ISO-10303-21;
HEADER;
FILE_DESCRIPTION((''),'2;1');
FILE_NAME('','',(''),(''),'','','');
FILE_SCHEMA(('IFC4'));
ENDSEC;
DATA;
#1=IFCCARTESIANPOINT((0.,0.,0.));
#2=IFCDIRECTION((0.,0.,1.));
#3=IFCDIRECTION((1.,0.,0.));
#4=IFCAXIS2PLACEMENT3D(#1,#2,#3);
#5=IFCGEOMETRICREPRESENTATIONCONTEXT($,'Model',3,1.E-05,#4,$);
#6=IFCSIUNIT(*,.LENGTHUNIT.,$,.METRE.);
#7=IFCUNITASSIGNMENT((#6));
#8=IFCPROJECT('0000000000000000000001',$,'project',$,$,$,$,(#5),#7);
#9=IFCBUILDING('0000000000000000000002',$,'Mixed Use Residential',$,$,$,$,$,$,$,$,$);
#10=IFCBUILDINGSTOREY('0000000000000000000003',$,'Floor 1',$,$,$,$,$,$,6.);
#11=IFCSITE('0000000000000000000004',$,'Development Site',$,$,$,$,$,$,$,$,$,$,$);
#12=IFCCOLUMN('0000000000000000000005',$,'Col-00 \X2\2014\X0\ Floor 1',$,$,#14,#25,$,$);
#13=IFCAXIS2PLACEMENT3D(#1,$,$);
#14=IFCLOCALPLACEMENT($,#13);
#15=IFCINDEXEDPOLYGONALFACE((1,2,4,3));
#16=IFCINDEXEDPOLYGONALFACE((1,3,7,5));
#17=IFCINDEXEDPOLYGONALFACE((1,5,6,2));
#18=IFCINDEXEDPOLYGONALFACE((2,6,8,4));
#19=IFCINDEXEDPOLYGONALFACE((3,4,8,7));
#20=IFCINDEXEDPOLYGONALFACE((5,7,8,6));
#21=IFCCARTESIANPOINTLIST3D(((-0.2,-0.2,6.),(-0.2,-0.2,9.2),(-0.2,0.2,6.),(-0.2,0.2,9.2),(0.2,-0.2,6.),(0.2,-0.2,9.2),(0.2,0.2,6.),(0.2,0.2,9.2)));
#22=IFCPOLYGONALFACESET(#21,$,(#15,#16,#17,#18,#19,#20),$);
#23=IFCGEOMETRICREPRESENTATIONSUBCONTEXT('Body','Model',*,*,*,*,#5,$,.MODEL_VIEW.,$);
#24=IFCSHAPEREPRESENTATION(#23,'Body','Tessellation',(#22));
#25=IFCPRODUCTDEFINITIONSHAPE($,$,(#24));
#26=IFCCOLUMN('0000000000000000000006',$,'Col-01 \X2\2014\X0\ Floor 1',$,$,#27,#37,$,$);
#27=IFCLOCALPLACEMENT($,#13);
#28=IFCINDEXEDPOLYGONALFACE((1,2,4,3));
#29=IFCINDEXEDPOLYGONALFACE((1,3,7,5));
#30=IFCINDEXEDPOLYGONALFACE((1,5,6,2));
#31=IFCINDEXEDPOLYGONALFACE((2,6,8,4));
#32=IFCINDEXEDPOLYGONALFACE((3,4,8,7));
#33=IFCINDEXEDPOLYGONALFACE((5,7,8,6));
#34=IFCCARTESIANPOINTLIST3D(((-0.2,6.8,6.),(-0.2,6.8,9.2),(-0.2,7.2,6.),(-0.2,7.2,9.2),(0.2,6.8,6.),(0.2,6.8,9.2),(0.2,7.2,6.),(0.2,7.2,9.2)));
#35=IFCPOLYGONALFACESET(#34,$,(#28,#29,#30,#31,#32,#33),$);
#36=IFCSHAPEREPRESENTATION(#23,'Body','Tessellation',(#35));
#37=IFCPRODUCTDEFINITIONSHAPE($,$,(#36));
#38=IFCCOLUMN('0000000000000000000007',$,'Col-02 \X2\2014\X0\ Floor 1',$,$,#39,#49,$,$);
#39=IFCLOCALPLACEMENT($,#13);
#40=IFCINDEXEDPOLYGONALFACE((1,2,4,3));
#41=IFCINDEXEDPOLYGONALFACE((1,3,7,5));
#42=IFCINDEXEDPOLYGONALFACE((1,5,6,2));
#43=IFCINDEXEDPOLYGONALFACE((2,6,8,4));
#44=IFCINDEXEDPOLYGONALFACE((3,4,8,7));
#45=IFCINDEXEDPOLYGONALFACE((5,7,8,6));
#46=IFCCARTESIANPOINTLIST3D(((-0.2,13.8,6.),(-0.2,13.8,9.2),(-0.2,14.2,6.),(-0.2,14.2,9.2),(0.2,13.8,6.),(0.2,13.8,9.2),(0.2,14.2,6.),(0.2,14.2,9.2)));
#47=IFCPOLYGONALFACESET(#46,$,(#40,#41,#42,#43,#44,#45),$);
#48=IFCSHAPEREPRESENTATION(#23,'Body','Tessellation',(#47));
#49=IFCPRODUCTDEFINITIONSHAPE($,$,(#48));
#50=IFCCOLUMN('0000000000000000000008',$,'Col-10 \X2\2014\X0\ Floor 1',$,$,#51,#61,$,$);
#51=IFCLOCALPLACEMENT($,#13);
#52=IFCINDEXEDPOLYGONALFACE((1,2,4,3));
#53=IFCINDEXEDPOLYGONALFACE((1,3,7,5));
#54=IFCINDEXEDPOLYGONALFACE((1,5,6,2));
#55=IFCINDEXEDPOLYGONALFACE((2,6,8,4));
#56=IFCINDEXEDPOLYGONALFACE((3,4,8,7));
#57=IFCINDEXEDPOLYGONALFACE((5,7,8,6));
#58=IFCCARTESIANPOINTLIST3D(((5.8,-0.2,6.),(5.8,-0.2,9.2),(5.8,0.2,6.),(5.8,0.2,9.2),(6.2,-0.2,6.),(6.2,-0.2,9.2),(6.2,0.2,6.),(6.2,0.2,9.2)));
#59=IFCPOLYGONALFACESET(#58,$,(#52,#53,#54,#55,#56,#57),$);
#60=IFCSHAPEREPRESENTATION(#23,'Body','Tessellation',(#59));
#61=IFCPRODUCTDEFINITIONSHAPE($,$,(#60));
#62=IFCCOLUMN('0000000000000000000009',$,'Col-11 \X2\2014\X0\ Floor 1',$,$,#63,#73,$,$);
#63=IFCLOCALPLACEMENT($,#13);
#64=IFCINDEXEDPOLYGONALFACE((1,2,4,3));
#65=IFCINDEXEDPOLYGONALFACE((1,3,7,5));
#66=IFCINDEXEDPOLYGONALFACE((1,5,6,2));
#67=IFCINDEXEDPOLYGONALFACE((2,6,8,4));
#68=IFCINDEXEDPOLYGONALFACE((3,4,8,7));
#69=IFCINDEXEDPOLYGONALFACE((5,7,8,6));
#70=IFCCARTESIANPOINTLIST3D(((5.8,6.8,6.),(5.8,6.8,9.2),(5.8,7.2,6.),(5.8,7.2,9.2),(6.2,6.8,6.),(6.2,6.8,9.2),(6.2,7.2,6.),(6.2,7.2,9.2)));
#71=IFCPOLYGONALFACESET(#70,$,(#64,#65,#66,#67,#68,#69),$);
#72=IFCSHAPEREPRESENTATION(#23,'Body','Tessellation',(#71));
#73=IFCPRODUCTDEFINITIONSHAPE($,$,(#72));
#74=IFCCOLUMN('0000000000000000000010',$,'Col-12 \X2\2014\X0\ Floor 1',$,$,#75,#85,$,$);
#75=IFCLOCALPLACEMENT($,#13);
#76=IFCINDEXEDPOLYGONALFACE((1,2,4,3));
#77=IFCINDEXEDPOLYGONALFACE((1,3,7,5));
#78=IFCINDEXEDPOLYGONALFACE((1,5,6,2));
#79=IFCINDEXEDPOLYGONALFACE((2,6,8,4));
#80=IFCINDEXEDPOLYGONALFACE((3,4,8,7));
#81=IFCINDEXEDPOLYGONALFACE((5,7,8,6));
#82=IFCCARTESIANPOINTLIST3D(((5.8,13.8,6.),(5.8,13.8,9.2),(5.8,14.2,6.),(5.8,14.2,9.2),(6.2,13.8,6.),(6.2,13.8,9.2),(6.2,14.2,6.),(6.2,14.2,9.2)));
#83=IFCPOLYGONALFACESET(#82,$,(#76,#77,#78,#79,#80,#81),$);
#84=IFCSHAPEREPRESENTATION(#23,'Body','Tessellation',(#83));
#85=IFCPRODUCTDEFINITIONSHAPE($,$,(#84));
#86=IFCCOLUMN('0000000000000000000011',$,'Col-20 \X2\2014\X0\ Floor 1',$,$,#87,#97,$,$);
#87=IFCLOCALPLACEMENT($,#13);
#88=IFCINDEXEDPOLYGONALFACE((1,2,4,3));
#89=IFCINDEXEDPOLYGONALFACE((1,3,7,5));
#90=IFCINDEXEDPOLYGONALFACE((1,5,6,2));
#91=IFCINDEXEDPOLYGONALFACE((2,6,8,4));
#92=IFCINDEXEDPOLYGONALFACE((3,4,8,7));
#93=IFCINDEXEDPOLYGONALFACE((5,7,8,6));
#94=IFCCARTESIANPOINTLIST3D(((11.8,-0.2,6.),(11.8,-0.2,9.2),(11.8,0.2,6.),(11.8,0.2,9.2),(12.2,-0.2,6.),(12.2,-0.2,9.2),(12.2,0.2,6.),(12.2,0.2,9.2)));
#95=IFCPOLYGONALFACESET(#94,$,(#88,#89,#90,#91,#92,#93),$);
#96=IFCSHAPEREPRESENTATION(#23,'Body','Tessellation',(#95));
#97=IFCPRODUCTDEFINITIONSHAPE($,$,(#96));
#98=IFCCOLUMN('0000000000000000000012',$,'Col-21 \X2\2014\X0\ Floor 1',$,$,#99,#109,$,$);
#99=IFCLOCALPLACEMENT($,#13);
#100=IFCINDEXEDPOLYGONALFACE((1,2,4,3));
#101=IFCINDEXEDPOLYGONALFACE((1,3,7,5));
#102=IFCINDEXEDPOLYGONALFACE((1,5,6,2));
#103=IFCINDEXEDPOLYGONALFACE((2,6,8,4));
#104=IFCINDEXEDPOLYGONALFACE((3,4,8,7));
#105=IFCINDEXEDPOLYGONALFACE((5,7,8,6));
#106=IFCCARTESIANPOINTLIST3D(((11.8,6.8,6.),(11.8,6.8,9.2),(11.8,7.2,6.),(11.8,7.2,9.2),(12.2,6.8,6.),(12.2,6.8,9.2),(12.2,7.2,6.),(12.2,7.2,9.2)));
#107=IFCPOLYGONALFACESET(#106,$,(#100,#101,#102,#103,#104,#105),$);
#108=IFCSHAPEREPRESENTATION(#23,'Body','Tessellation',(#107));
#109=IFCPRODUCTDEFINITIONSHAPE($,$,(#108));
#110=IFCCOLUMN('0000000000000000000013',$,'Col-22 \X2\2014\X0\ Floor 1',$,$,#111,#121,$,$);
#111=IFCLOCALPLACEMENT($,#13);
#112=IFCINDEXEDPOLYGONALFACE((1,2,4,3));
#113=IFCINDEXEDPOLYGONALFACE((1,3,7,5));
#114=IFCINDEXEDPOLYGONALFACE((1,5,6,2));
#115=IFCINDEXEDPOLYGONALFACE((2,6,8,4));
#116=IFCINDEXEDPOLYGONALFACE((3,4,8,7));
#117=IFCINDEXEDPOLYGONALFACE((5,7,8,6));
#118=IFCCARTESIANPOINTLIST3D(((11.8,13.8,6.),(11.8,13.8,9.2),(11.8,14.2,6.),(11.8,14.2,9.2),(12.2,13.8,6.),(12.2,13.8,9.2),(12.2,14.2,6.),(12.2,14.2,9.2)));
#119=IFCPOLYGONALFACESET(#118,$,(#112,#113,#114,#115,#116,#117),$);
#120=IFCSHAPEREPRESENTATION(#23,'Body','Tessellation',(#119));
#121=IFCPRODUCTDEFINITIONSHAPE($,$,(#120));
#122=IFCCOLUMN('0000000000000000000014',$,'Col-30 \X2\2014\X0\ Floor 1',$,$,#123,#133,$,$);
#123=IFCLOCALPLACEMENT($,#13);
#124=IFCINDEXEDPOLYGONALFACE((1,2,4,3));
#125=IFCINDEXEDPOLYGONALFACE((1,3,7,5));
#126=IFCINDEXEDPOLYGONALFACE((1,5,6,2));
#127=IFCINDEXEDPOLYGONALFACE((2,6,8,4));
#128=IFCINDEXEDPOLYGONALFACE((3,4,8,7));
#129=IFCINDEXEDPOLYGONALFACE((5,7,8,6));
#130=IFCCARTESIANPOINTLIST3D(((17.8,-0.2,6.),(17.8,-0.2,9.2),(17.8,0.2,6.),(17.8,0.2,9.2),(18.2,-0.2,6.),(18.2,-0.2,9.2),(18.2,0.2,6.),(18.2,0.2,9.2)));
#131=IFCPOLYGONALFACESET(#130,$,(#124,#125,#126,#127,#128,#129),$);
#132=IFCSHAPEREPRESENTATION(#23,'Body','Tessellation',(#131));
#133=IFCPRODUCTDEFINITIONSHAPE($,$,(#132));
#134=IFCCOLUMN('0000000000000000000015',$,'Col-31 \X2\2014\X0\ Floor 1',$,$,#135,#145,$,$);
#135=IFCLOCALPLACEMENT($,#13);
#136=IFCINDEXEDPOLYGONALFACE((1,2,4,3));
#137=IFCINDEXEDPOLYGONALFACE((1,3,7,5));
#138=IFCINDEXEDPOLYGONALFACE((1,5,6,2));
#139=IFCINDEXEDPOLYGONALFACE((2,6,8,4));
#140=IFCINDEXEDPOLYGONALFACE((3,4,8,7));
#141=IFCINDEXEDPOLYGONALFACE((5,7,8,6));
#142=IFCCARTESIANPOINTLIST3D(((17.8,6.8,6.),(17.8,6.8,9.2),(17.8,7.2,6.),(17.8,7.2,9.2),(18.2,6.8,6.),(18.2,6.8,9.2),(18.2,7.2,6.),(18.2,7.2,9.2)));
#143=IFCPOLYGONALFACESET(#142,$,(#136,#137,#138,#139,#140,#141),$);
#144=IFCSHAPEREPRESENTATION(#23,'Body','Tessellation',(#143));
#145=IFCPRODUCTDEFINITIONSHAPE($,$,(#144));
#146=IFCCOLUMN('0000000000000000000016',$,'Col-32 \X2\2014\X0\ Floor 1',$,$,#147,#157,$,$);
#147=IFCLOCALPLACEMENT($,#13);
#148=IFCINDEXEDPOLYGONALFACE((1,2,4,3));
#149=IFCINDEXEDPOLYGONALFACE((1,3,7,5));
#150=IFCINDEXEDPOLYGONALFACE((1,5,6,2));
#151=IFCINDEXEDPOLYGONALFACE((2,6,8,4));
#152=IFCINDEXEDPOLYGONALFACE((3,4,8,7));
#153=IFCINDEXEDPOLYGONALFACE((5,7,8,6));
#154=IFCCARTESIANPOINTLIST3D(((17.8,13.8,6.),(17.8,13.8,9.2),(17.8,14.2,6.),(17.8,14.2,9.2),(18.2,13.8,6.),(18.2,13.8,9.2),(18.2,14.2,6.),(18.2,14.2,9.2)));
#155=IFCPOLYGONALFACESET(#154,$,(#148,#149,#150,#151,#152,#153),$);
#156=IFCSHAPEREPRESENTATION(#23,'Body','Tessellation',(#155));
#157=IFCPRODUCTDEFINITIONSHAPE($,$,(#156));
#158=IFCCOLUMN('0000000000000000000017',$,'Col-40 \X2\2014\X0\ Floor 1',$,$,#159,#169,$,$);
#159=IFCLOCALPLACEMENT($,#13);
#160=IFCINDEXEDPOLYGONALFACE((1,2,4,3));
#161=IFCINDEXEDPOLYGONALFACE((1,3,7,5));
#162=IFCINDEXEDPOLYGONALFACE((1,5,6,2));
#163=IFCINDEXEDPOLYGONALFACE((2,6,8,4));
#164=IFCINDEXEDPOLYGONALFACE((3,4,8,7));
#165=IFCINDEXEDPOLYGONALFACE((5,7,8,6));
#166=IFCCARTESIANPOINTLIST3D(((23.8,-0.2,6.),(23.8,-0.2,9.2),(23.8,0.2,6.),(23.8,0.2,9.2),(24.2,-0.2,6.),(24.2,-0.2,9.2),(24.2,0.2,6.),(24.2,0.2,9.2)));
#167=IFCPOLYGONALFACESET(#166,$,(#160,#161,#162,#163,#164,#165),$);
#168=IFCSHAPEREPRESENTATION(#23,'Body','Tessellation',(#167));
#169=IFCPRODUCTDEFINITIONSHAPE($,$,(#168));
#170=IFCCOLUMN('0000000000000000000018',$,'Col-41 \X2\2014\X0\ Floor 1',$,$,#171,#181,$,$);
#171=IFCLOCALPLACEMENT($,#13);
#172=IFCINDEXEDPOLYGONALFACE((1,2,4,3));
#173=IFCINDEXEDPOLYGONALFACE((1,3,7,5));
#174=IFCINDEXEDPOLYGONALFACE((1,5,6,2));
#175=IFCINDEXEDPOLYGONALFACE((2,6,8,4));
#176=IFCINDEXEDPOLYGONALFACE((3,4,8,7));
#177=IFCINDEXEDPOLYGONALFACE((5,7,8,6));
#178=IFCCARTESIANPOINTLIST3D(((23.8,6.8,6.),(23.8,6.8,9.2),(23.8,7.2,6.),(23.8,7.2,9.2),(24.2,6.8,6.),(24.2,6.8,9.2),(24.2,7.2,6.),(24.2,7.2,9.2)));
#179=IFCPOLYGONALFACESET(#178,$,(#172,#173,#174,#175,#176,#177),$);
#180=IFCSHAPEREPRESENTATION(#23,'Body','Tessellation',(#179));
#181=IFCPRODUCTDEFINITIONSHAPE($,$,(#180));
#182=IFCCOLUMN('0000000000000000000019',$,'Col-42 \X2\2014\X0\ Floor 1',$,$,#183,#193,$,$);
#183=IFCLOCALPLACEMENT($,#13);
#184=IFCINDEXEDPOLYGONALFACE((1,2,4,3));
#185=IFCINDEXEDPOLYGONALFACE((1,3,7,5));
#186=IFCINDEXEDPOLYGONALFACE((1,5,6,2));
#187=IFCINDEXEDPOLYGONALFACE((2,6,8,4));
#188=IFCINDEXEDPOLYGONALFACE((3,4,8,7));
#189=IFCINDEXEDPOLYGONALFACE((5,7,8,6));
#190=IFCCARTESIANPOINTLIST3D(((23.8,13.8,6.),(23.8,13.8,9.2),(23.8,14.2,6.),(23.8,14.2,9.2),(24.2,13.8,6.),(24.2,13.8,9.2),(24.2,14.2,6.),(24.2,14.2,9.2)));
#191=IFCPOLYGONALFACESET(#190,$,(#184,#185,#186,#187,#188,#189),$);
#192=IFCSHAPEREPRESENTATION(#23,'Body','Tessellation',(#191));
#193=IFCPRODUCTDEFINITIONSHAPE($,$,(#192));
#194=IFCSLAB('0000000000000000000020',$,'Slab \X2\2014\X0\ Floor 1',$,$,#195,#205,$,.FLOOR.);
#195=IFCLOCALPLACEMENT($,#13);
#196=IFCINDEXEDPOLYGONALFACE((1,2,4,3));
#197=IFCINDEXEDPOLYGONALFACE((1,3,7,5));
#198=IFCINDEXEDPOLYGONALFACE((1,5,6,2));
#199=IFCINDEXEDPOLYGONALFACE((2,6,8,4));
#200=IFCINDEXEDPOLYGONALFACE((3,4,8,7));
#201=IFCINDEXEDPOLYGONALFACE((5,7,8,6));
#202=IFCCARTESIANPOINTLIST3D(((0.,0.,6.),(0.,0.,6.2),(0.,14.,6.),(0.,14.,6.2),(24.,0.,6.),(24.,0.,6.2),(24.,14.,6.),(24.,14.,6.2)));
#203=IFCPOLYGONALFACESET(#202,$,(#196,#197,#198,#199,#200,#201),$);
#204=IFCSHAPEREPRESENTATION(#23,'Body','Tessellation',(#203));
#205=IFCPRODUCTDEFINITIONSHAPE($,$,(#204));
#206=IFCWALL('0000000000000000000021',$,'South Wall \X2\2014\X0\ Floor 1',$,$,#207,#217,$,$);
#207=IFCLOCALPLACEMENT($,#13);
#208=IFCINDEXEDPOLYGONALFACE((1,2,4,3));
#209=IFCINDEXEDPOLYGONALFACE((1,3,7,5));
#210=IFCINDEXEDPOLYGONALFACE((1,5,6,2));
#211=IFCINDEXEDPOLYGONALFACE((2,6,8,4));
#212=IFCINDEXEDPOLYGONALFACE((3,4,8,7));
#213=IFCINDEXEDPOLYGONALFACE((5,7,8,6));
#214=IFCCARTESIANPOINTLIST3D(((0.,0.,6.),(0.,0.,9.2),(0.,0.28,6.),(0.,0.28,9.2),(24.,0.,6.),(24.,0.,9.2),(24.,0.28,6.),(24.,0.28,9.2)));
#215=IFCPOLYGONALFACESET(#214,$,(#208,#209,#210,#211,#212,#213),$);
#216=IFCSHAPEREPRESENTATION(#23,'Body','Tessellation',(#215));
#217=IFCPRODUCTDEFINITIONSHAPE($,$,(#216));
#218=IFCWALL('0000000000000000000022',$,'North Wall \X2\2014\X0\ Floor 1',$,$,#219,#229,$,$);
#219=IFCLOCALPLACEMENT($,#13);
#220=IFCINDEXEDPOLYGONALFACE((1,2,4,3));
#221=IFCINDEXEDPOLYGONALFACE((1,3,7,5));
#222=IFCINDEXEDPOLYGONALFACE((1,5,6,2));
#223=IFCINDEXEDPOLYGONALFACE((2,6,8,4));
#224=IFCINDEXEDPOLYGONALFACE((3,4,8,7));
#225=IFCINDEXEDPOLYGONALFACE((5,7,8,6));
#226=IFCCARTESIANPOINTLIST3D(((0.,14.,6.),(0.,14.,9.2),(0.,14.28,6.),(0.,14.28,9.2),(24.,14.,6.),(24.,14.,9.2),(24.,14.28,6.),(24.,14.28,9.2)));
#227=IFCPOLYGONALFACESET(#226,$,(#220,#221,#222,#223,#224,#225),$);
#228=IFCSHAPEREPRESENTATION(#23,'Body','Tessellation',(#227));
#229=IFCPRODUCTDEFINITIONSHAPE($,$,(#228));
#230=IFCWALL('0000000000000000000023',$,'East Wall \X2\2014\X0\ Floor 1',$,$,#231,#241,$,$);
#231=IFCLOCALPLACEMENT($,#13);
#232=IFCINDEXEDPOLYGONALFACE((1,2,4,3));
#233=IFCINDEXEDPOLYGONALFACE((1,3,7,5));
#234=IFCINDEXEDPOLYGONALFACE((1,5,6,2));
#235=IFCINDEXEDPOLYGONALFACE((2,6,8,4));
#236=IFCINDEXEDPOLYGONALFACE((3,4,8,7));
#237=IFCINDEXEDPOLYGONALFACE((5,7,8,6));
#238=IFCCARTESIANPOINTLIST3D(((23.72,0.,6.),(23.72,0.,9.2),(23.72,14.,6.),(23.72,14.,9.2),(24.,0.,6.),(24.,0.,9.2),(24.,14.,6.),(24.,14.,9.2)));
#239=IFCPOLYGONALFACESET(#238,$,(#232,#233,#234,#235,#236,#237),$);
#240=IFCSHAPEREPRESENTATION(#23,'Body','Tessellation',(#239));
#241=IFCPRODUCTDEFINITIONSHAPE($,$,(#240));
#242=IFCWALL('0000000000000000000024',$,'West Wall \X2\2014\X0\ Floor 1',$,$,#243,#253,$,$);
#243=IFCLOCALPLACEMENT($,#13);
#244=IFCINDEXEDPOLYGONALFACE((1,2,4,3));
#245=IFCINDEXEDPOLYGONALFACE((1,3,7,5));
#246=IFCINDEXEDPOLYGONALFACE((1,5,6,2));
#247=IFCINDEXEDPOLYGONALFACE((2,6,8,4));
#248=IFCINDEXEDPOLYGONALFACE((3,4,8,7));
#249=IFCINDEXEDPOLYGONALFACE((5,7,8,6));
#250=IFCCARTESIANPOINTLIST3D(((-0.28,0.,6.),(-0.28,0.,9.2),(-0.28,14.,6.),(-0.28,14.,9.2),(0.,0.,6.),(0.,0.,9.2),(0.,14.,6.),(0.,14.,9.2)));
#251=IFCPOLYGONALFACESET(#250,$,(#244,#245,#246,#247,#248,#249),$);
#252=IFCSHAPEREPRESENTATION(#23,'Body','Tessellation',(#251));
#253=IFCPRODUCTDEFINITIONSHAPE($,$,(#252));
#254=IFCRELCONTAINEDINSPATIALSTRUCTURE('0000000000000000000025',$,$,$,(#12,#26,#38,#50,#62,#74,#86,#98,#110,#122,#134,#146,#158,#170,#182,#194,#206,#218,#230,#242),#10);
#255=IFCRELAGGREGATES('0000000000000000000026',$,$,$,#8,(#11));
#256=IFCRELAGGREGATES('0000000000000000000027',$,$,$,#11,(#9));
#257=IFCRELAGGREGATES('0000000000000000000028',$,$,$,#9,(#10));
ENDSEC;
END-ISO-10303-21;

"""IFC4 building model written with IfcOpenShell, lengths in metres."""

from ifc_helpers import new_model, si_unit, frame, origin_with_axes, place, context, subcontext, project, spatial, indexed_curve, rectangle, outline, extrude, element, save


model = new_model("IFC4")

# Units and contexts
model_context = context("Model", 3, precision=1e-05, world=origin_with_axes())
body_context = subcontext(model_context, "Body", "Model", "MODEL_VIEW")
ifc_project = project(units=[si_unit("LENGTHUNIT", "METRE")], contexts=[model_context])

# Site, building, storey
site = spatial("IfcSite", under=ifc_project, Name="Development Site")
building = spatial("IfcBuilding", under=site, Name="Mixed Use Residential")
storey = spatial("IfcBuildingStorey", under=building, Name="Floor 1", Elevation=6.0)

# Columns
for number, where, z_axis, x_axis, name in (
    (1, (0.0, 0.0, 6.0), (0.0, 0.0, 1.0), (1.0, 0.0, 0.0), "Col-00 — Floor 1"),
    (2, (0.0, 7.0, 6.0), (0.0, 0.0, 1.0), (1.0, 0.0, 0.0), "Col-01 — Floor 1"),
    (3, (0.0, 14.0, 6.0), (0.0, 0.0, 1.0), (1.0, 0.0, 0.0), "Col-02 — Floor 1"),
    (4, (6.0, 0.0, 6.0), (0.0, 0.0, 1.0), (1.0, 0.0, 0.0), "Col-10 — Floor 1"),
    (5, (6.0, 7.0, 6.0), (0.0, 0.0, 1.0), (1.0, 0.0, 0.0), "Col-11 — Floor 1"),
    (6, (6.0, 14.0, 6.0), (0.0, 0.0, 1.0), (1.0, 0.0, 0.0), "Col-12 — Floor 1"),
    (7, (12.0, 0.0, 6.0), (0.0, 0.0, 1.0), (1.0, 0.0, 0.0), "Col-20 — Floor 1"),
    (8, (12.0, 7.0, 6.0), (0.0, 0.0, 1.0), (1.0, 0.0, 0.0), "Col-21 — Floor 1"),
    (9, (12.0, 14.0, 6.0), (0.0, 0.0, 1.0), (1.0, 0.0, 0.0), "Col-22 — Floor 1"),
    (10, (18.0, 0.0, 6.0), (0.0, 0.0, 1.0), (1.0, 0.0, 0.0), "Col-30 — Floor 1"),
    (11, (18.0, 7.0, 6.0), (0.0, 0.0, 1.0), (1.0, 0.0, 0.0), "Col-31 — Floor 1"),
    (12, (18.0, 14.0, 6.0), (0.0, 0.0, 1.0), (1.0, 0.0, 0.0), "Col-32 — Floor 1"),
    (13, (24.0, 0.0, 6.0), (0.0, 0.0, 1.0), (1.0, 0.0, 0.0), "Col-40 — Floor 1"),
    (14, (24.0, 7.0, 6.0), (0.0, 0.0, 1.0), (1.0, 0.0, 0.0), "Col-41 — Floor 1"),
    (15, (24.0, 14.0, 6.0), (0.0, 0.0, 1.0), (1.0, 0.0, 0.0), "Col-42 — Floor 1"),
):
    element("IfcColumn", number, at=place(None, frame(where, z_axis=z_axis, x_axis=x_axis)), inside=storey, Name=name, context=body_context, shape_type="SweptSolid", body=[
        extrude(rectangle(XDim=0.4, YDim=0.4), origin_with_axes(), (0.0, 0.0, 1.0), 3.2),
    ])

# Slab
slab_placement = place(None, frame((0.0, 0.0, 6.0), z_axis=(0.0, 0.0, 1.0), x_axis=(1.0, 0.0, 0.0)))
element("IfcSlab", 16, at=slab_placement, inside=storey, Name="Slab — Floor 1", PredefinedType="FLOOR", context=body_context, shape_type="SweptSolid", body=[
    extrude(outline(indexed_curve([(0.0, 0.0), (24.0, 0.0), (24.0, 14.0), (0.0, 14.0), (0.0, 0.0)])), None, (0.0, 0.0, 1.0), 0.2),
])

# Walls
for number, where, z_axis, x_axis, name in (
    (17, (0.0, 0.0, 6.0), (0.0, 0.0, 1.0), (1.0, 0.0, 0.0), "South Wall — Floor 1"),
    (18, (0.0, 14.0, 6.0), (0.0, 0.0, 1.0), (1.0, 0.0, 0.0), "North Wall — Floor 1"),
):
    element("IfcWall", number, at=place(None, frame(where, z_axis=z_axis, x_axis=x_axis)), inside=storey, Name=name, context=body_context, shape_type="SweptSolid", body=[
        extrude(outline(indexed_curve([(0.0, 0.0), (0.0, 0.28), (24.0, 0.28), (24.0, 0.0), (0.0, 0.0)], self_intersect=False)), origin_with_axes(), (0.0, 0.0, 1.0), 3.2),
    ])
for number, where, z_axis, x_axis, name in (
    (19, (24.0, 0.0, 6.0), (0.0, 0.0, 1.0), (0.0, 1.0, 0.0), "East Wall — Floor 1"),
    (20, (0.0, 0.0, 6.0), (0.0, 0.0, 1.0), (0.0, 1.0, 0.0), "West Wall — Floor 1"),
):
    element("IfcWall", number, at=place(None, frame(where, z_axis=z_axis, x_axis=x_axis)), inside=storey, Name=name, context=body_context, shape_type="SweptSolid", body=[
        extrude(outline(indexed_curve([(0.0, 0.0), (0.0, 0.28), (14.0, 0.28), (14.0, 0.0), (0.0, 0.0)], self_intersect=False)), origin_with_axes(), (0.0, 0.0, 1.0), 3.2),
    ])

save(model, "model.ifc")
